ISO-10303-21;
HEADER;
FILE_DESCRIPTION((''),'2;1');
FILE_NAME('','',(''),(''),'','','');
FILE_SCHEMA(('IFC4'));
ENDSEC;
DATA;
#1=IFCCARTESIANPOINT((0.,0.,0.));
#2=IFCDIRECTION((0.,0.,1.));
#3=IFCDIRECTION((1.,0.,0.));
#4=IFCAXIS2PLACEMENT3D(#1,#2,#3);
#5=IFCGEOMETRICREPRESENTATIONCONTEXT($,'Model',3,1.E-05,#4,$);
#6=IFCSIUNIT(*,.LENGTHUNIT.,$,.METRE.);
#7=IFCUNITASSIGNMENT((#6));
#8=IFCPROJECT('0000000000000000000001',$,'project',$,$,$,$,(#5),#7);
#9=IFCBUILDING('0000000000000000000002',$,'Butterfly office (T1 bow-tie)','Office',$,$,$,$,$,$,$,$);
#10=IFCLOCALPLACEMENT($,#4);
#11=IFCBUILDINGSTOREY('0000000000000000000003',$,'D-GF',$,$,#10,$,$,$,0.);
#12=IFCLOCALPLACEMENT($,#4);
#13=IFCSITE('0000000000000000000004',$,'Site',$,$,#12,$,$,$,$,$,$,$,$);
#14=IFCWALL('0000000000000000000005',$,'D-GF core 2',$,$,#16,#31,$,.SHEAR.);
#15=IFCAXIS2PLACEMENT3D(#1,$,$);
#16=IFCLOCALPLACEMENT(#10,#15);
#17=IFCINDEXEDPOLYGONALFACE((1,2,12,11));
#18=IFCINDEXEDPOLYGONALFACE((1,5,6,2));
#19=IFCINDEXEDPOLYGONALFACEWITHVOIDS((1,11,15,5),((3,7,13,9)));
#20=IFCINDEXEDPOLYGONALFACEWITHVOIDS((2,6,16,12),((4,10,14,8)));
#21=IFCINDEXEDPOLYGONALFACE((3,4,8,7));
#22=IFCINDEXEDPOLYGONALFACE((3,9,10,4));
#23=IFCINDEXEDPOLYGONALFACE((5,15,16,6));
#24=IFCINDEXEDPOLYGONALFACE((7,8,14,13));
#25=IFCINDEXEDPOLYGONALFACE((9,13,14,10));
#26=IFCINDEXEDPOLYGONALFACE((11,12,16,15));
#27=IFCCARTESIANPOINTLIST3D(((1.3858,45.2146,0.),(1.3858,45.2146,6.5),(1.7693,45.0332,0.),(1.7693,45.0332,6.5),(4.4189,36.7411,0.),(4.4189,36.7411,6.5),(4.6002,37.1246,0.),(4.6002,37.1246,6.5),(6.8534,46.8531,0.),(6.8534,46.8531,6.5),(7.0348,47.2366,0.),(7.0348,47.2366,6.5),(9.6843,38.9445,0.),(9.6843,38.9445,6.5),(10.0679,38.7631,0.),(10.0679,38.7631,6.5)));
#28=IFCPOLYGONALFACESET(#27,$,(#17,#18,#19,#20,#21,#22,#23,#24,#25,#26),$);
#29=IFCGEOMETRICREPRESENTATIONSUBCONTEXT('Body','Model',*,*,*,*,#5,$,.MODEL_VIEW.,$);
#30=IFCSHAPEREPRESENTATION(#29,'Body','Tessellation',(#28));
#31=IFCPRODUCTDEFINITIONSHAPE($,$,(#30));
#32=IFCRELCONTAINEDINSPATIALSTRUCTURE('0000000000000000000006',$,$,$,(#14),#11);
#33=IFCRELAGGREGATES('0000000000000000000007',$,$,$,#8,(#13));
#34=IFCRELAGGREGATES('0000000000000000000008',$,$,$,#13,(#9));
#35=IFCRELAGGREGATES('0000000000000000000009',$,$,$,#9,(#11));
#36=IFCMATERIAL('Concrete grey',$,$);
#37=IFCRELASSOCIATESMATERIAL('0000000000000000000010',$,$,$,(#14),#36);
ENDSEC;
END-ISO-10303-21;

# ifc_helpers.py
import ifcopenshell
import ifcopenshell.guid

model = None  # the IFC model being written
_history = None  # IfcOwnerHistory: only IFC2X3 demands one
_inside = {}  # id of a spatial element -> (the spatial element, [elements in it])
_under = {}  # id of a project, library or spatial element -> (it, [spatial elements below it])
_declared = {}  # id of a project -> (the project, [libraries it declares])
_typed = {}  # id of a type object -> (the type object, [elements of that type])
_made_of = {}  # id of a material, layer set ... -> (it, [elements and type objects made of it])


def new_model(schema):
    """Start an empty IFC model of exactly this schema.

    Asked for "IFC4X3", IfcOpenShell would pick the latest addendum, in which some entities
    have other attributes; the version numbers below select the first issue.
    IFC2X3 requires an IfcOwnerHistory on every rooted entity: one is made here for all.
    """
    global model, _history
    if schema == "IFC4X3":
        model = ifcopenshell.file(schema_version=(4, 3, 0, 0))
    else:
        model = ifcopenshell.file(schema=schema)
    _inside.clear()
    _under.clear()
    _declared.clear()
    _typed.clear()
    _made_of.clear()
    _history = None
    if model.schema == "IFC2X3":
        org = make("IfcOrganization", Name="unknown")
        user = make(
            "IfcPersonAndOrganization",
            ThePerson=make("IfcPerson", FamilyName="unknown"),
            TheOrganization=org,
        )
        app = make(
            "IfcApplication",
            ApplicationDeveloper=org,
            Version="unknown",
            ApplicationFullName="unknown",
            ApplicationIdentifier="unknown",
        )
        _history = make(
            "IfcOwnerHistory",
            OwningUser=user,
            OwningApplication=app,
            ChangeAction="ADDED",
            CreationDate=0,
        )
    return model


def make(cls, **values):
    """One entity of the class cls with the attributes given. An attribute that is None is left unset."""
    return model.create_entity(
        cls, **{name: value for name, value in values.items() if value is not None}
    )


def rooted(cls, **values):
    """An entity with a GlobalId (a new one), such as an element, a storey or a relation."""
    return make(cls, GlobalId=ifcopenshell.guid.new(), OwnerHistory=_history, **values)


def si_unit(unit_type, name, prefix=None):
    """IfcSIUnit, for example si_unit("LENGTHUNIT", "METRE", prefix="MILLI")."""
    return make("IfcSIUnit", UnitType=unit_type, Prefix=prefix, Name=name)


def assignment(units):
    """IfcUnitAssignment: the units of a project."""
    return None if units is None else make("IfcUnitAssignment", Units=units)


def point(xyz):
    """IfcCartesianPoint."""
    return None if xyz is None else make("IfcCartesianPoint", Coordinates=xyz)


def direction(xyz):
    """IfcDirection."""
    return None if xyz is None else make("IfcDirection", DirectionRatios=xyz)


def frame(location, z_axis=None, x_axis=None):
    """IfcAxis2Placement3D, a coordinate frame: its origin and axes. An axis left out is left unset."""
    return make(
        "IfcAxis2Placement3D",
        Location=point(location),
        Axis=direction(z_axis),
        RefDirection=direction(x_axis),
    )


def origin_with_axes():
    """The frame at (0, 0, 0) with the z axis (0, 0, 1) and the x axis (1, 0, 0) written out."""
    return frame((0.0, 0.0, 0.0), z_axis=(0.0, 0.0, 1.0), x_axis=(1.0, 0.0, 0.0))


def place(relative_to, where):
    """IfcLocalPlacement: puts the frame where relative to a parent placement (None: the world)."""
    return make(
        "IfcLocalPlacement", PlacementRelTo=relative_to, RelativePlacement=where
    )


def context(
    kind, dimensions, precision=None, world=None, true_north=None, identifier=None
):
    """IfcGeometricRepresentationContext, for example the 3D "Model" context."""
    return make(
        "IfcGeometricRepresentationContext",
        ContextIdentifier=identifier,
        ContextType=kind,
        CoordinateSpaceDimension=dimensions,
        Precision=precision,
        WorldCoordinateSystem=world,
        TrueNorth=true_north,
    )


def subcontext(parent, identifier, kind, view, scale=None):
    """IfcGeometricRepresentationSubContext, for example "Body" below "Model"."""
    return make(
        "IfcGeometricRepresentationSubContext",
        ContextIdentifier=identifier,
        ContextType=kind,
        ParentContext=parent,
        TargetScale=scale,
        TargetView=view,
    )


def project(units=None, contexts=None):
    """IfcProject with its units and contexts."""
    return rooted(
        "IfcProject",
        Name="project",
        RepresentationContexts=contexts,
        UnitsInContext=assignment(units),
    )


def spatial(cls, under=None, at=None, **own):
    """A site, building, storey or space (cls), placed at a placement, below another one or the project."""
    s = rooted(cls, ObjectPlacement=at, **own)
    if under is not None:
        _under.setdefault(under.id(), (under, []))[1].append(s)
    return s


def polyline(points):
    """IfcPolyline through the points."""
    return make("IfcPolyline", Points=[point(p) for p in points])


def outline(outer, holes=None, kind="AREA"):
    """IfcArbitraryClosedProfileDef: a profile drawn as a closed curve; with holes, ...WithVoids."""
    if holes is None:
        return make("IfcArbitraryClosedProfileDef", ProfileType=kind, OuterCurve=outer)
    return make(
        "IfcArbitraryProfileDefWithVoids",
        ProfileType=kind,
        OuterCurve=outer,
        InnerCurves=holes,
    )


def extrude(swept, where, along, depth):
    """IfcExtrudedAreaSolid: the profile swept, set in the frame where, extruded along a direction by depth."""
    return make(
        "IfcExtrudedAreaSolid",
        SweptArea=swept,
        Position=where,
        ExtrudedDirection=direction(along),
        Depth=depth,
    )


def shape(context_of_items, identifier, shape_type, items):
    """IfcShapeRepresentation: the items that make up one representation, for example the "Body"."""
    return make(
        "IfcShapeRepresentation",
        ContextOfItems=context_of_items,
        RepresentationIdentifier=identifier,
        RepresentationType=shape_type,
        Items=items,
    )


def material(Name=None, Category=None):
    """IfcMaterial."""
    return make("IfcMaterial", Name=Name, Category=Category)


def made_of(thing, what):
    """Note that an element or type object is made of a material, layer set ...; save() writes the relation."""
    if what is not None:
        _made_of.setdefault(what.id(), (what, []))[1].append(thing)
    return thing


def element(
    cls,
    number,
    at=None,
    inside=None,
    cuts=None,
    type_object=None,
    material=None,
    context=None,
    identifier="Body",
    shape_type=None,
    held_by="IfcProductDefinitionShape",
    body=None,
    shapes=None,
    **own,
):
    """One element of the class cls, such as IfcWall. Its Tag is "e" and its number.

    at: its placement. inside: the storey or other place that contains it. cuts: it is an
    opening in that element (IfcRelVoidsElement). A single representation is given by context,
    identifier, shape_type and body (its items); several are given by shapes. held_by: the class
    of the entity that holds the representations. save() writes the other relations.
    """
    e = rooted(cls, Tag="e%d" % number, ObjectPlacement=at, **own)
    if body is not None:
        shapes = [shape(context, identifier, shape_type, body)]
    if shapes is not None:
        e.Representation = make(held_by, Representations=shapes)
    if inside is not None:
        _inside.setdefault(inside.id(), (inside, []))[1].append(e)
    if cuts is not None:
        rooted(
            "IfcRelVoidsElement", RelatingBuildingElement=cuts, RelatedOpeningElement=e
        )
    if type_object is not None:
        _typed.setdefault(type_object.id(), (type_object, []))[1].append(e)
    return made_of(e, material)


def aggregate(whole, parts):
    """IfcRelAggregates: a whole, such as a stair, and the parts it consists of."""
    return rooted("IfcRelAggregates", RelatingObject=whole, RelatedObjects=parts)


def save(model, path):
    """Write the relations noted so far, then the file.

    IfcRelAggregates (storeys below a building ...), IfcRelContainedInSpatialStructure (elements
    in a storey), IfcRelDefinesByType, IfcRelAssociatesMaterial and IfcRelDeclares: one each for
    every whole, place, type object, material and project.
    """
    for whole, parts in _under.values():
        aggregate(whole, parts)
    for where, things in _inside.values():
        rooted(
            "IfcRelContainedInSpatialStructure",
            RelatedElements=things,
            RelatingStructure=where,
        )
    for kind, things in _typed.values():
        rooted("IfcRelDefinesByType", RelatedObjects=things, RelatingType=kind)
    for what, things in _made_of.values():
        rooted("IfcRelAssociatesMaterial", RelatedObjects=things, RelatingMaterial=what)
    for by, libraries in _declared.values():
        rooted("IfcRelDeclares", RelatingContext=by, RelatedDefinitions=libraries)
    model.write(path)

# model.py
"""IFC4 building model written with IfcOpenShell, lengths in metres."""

from ifc_helpers import new_model, si_unit, origin_with_axes, place, context, subcontext, project, spatial, polyline, outline, extrude, material, element, save


model = new_model("IFC4")

# Units and contexts
model_context = context("Model", 3, precision=1e-05, world=origin_with_axes())
body_context = subcontext(model_context, "Body", "Model", "MODEL_VIEW")
ifc_project = project(units=[si_unit("LENGTHUNIT", "METRE")], contexts=[model_context])

# Site, building, storey
site_placement = place(None, origin_with_axes())
site = spatial("IfcSite", under=ifc_project, at=site_placement, Name="Site")
building = spatial("IfcBuilding", under=site, Name="Butterfly office (T1 bow-tie)", Description="Office")
storey_placement = place(None, origin_with_axes())
storey = spatial("IfcBuildingStorey", under=building, at=storey_placement, Name="D-GF", Elevation=0.0)

# Shared definitions
ifc_material_1 = material(Name="Concrete grey")

# Wall
wall_1_placement = place(storey_placement, origin_with_axes())
element("IfcWall", 1, at=wall_1_placement, inside=storey, material=ifc_material_1, Name="D-GF core 2", PredefinedType="SHEAR", context=body_context, shape_type="SweptSolid", body=[
    extrude(outline(polyline([(4.4189, 36.7411), (10.0679, 38.7631), (7.0348, 47.2366), (1.3858, 45.2146), (4.4189, 36.7411)]), holes=[polyline([(4.6002, 37.1246), (9.6843, 38.9445), (6.8534, 46.8531), (1.7693, 45.0332), (4.6002, 37.1246)])]), origin_with_axes(), (0.0, 0.0, 1.0), 6.5),
])

save(model, "model.ifc")
